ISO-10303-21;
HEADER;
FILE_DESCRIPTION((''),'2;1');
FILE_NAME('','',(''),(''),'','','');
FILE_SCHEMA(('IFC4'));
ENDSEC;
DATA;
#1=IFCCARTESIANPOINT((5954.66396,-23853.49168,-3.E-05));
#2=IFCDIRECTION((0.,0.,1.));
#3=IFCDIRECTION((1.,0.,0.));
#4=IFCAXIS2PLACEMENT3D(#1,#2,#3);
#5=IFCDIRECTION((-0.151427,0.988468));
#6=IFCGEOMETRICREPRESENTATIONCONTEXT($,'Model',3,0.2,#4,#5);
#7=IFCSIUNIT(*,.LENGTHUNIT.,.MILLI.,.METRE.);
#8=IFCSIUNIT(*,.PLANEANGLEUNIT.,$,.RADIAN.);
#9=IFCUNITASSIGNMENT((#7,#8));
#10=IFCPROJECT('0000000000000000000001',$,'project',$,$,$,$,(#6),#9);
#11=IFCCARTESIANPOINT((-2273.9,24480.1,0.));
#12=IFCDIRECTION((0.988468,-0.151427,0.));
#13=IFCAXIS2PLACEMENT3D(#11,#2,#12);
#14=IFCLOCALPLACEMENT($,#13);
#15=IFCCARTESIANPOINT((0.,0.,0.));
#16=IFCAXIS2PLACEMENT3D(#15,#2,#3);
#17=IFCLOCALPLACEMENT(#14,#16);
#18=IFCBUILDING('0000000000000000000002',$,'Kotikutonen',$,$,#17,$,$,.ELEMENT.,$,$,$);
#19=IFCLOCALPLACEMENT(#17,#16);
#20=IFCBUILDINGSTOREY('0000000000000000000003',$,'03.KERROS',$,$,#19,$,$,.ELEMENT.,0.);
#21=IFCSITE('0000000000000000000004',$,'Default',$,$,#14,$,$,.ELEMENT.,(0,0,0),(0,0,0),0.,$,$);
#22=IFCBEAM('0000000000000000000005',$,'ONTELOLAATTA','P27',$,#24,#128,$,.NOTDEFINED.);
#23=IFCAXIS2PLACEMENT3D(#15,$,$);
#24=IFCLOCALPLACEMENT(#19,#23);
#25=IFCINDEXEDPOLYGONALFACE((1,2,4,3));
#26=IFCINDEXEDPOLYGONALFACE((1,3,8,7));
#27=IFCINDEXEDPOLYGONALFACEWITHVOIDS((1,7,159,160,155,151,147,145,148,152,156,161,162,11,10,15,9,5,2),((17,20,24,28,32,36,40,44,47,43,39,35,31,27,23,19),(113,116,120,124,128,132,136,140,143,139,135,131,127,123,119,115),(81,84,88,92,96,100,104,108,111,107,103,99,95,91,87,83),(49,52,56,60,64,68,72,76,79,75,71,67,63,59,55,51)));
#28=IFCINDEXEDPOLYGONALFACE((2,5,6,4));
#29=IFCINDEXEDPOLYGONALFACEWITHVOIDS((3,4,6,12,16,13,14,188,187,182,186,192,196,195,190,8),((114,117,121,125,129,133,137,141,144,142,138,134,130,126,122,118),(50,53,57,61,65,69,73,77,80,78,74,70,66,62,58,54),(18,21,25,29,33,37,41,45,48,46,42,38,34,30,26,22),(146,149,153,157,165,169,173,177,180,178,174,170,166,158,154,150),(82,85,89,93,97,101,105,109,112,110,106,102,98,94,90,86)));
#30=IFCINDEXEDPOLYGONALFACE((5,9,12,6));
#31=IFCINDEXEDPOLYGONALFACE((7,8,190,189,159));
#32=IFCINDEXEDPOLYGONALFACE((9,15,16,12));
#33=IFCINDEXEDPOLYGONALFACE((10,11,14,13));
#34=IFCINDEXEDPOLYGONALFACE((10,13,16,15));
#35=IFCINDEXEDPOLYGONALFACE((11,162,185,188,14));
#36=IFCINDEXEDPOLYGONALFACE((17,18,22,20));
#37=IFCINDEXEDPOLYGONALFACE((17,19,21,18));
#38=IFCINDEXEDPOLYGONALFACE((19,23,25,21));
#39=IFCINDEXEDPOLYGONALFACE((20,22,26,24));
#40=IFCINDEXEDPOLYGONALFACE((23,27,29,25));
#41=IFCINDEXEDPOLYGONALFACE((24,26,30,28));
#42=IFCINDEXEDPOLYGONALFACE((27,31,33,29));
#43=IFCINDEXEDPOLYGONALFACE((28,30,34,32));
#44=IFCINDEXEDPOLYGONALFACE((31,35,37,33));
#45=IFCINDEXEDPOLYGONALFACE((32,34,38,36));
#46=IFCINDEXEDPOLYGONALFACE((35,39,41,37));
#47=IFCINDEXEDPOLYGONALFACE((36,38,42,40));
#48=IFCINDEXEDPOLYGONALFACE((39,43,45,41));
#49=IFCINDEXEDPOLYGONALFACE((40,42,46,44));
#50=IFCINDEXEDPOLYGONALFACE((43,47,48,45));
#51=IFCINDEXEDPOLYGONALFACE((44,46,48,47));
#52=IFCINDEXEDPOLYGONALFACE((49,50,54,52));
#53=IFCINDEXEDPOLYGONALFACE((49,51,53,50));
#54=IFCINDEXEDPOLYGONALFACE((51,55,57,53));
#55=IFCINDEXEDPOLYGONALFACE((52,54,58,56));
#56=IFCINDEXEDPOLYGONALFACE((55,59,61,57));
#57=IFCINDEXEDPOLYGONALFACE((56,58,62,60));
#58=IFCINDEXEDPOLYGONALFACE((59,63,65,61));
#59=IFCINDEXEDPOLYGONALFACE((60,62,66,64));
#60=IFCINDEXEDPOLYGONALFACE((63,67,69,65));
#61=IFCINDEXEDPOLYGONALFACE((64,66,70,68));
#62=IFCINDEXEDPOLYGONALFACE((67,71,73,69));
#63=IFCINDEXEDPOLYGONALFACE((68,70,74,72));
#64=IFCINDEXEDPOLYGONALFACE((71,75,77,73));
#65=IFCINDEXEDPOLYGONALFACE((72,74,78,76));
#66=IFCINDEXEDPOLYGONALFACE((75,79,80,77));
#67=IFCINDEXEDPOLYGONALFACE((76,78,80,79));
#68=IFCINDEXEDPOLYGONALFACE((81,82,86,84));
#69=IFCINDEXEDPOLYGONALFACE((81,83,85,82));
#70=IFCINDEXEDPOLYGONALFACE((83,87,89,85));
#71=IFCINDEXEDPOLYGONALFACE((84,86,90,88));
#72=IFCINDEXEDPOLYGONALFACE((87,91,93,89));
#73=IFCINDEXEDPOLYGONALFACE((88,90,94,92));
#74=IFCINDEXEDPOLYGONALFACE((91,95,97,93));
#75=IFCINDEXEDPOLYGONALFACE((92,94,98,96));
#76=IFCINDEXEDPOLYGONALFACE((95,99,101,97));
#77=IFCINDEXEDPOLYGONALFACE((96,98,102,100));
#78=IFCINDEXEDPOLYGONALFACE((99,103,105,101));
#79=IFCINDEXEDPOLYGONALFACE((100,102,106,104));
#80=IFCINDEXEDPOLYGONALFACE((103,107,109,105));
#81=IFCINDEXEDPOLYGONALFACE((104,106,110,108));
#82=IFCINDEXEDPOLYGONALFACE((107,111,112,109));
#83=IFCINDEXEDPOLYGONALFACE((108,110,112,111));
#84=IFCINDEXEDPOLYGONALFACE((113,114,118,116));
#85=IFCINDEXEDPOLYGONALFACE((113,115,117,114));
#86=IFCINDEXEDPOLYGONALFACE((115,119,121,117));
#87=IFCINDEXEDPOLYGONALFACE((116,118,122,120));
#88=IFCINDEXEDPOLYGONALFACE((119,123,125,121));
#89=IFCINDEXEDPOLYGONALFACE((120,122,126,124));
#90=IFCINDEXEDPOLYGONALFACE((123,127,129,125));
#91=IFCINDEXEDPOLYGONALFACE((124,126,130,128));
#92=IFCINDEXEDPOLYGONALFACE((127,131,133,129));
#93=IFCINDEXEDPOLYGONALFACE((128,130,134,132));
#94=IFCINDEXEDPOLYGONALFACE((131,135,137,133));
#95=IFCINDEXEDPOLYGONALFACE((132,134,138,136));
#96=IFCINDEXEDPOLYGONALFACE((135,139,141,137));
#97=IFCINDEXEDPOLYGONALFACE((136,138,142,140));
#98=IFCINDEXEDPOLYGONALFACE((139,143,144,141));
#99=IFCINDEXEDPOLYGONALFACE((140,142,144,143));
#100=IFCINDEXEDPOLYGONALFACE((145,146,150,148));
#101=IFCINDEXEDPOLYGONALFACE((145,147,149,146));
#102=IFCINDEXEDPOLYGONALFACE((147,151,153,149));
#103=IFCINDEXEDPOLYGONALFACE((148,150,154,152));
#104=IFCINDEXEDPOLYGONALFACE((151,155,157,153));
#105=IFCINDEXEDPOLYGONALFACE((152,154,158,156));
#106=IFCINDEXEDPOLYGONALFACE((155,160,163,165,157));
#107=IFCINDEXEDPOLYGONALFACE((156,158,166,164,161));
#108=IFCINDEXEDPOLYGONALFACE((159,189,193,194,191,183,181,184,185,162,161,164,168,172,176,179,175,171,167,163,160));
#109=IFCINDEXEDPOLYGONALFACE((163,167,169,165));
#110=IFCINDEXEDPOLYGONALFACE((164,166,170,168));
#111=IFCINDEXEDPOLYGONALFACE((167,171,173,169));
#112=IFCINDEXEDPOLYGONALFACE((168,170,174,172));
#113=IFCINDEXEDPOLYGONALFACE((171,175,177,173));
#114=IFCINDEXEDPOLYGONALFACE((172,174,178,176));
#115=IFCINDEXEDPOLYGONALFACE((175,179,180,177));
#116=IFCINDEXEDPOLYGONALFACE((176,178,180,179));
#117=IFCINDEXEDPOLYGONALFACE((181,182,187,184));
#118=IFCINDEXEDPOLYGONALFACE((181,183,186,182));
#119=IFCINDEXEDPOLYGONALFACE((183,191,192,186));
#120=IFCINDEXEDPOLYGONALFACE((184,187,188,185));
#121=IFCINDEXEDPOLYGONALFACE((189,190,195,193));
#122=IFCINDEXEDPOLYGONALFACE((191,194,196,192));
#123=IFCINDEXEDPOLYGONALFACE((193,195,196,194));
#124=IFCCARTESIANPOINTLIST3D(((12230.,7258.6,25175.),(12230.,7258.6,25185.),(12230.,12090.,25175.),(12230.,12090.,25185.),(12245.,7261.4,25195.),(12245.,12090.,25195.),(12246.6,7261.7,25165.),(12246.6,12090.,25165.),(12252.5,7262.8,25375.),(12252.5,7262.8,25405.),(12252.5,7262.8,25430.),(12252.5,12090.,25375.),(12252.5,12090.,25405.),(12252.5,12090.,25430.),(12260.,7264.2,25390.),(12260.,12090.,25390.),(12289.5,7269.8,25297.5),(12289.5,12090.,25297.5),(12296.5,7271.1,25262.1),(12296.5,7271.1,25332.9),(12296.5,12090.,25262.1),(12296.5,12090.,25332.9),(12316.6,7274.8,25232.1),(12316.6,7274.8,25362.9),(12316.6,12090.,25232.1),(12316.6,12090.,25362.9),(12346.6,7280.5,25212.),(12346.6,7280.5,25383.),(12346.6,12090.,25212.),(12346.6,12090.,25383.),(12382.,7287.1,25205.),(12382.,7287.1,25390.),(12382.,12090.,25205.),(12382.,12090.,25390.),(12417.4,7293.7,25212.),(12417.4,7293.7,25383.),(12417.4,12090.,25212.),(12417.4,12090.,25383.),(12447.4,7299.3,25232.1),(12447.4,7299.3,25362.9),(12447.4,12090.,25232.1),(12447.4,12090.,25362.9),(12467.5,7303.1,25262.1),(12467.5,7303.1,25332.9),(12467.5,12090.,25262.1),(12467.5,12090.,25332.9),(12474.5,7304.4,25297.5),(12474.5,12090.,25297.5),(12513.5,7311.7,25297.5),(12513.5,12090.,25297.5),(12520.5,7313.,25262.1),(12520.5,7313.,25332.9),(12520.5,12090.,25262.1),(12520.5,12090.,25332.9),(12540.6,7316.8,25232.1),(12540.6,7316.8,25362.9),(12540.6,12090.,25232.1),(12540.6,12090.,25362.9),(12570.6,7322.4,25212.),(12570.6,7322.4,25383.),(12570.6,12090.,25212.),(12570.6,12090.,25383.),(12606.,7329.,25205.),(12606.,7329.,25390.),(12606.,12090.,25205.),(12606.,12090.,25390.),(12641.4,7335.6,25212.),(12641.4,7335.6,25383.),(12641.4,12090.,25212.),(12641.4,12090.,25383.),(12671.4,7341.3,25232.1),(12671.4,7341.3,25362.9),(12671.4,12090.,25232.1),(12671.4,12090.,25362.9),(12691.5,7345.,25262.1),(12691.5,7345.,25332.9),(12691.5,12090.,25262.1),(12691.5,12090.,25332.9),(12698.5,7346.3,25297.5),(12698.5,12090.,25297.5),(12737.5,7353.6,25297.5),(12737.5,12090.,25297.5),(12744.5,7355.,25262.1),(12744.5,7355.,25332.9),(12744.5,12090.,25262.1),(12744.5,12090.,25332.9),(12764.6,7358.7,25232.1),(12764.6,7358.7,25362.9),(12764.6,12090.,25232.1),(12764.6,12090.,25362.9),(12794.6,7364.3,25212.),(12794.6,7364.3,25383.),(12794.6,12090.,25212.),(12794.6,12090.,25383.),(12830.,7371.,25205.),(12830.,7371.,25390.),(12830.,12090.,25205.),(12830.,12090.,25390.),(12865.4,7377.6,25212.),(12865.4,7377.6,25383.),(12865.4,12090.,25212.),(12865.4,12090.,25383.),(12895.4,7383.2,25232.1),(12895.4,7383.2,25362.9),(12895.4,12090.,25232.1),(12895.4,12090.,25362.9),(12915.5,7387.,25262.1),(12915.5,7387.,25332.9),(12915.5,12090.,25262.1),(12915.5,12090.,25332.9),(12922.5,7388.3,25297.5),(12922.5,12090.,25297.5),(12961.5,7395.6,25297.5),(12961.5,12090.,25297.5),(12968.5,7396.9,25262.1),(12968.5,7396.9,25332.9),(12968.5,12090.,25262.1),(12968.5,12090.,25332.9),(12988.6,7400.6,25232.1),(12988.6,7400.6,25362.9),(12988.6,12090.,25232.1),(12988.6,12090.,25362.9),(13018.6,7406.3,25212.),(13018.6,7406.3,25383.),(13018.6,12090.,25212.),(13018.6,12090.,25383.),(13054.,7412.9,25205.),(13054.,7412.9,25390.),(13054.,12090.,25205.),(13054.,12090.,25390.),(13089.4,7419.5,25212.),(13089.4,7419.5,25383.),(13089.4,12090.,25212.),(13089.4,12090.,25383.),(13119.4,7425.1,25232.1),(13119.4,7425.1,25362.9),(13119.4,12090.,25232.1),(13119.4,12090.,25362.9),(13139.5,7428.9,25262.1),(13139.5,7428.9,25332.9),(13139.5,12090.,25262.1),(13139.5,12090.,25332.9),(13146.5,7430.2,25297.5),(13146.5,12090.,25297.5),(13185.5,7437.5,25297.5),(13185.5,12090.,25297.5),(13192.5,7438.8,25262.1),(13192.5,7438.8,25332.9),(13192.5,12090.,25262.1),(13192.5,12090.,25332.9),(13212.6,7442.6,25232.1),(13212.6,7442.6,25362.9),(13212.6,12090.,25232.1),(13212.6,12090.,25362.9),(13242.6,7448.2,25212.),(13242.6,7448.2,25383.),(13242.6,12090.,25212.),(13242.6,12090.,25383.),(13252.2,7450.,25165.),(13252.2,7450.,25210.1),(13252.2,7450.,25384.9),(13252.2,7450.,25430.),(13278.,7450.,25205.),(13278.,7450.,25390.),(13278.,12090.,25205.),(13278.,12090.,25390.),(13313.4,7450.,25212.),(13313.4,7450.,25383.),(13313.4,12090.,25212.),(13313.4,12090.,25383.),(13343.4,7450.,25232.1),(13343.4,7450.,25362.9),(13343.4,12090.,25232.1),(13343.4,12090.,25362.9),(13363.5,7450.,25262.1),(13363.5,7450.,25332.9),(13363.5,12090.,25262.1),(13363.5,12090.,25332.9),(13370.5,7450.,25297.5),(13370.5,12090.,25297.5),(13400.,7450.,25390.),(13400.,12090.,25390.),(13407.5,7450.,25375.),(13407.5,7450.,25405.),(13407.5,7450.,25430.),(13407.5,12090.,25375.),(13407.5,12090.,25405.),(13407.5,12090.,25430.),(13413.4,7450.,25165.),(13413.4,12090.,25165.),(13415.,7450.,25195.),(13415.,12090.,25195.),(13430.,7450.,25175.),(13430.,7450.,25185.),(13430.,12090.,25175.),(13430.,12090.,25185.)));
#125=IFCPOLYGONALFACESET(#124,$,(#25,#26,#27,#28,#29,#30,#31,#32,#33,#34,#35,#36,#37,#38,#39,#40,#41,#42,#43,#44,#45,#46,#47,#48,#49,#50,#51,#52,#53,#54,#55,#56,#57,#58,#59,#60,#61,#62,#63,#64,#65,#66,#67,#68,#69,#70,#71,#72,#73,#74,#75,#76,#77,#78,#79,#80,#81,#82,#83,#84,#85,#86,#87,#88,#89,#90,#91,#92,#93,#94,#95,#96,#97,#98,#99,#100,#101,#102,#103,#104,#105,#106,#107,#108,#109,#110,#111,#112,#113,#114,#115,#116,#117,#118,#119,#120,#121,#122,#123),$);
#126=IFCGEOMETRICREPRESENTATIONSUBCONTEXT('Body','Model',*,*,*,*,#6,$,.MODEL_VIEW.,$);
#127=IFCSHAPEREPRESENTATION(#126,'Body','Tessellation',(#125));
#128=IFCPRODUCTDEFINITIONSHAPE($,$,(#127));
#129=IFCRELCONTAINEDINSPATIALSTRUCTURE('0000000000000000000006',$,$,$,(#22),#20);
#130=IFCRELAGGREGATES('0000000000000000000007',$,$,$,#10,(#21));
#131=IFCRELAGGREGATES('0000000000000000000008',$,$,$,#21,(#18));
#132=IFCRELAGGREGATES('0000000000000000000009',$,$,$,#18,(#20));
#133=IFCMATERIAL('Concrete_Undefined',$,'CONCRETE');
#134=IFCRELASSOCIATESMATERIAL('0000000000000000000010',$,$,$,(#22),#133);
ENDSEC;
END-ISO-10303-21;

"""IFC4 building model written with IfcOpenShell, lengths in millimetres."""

from ifc_helpers import new_model, si_unit, direction, frame, origin_with_axes, place, context, subcontext, project, spatial, line, indexed_curve, outline, extrude, material, element, save


model = new_model("IFC4")

# Units and contexts
model_context = context("Model", 3, precision=0.2, world=frame((5954.66396, -23853.49168, -3e-05), z_axis=(0.0, 0.0, 1.0), x_axis=(1.0, 0.0, 0.0)), true_north=direction((-0.151427, 0.988468)))
body_context = subcontext(model_context, "Body", "Model", "MODEL_VIEW")
ifc_project = project(units=[si_unit("LENGTHUNIT", "METRE", prefix="MILLI"), si_unit("PLANEANGLEUNIT", "RADIAN")], contexts=[model_context])

# Site, building, storey
site_placement = place(None, frame((-2273.9, 24480.1, 0.0), z_axis=(0.0, 0.0, 1.0), x_axis=(0.988468, -0.151427, 0.0)))
site = spatial("IfcSite", under=ifc_project, at=site_placement, Name="Default", CompositionType="ELEMENT", RefLatitude=(0, 0, 0), RefLongitude=(0, 0, 0), RefElevation=0.0)
building_placement = place(site_placement, origin_with_axes())
building = spatial("IfcBuilding", under=site, at=building_placement, Name="Kotikutonen", CompositionType="ELEMENT")
storey_placement = place(building_placement, origin_with_axes())
storey = spatial("IfcBuildingStorey", under=building, at=storey_placement, Name="03.KERROS", CompositionType="ELEMENT", Elevation=0.0)

# Shared definitions
ifc_material_1 = material(Name="Concrete_Undefined", Category="CONCRETE")

# Beam, voiding feature
beam_1_placement = place(storey_placement, frame((12830.0, 12090.0, 25297.5), z_axis=(-1.0, 0.0, 0.0), x_axis=(0.0, -1.0, 0.0)))
beam_1 = element("IfcBeam", 1, at=beam_1_placement, inside=storey, material=ifc_material_1, Name="ONTELOLAATTA", Description="P27", PredefinedType="NOTDEFINED", context=body_context, shape_type="SolidModel", body=[
    extrude(outline(indexed_curve([(-600.0, -122.5), (-583.4, -132.5), (583.4, -132.5), (600.0, -122.5), (600.0, -112.5), (585.0, -102.5), (577.5, 77.5), (570.0, 92.5), (577.5, 107.5), (577.5, 132.5), (-577.5, 132.5), (-577.5, 107.5), (-570.0, 92.5), (-577.5, 77.5), (-585.0, -102.5), (-600.0, -112.5)], segments=[line(1, 2, 3, 4, 5, 6, 7, 8, 9, 10, 11, 12, 13, 14, 15, 16, 1)]), holes=[indexed_curve([(-448.0, -92.5), (-483.4, -85.5), (-513.4, -65.4), (-533.5, -35.4), (-540.5, 0.0), (-533.5, 35.4), (-513.4, 65.4), (-483.4, 85.5), (-448.0, 92.5), (-412.6, 85.5), (-382.6, 65.4), (-362.5, 35.4), (-355.5, 0.0), (-362.5, -35.4), (-382.6, -65.4), (-412.6, -85.5)], segments=[line(1, 2, 3, 4, 5, 6, 7, 8, 9, 10, 11, 12, 13, 14, 15, 16, 1)]), indexed_curve([(-224.0, -92.5), (-259.4, -85.5), (-289.4, -65.4), (-309.5, -35.4), (-316.5, 0.0), (-309.5, 35.4), (-289.4, 65.4), (-259.4, 85.5), (-224.0, 92.5), (-188.6, 85.5), (-158.6, 65.4), (-138.5, 35.4), (-131.5, 0.0), (-138.5, -35.4), (-158.6, -65.4), (-188.6, -85.5)], segments=[line(1, 2, 3, 4, 5, 6, 7, 8, 9, 10, 11, 12, 13, 14, 15, 16, 1)]), indexed_curve([(0.0, -92.5), (-35.4, -85.5), (-65.4, -65.4), (-85.5, -35.4), (-92.5, 0.0), (-85.5, 35.4), (-65.4, 65.4), (-35.4, 85.5), (0.0, 92.5), (35.4, 85.5), (65.4, 65.4), (85.5, 35.4), (92.5, 0.0), (85.5, -35.4), (65.4, -65.4), (35.4, -85.5)], segments=[line(1, 2, 3, 4, 5, 6, 7, 8, 9, 10, 11, 12, 13, 14, 15, 16, 1)]), indexed_curve([(224.0, -92.5), (188.6, -85.5), (158.6, -65.4), (138.5, -35.4), (131.5, 0.0), (138.5, 35.4), (158.6, 65.4), (188.6, 85.5), (224.0, 92.5), (259.4, 85.5), (289.4, 65.4), (309.5, 35.4), (316.5, 0.0), (309.5, -35.4), (289.4, -65.4), (259.4, -85.5)], segments=[line(1, 2, 3, 4, 5, 6, 7, 8, 9, 10, 11, 12, 13, 14, 15, 16, 1)]), indexed_curve([(448.0, -92.5), (412.6, -85.5), (382.6, -65.4), (362.5, -35.4), (355.5, 0.0), (362.5, 35.4), (382.6, 65.4), (412.6, 85.5), (448.0, 92.5), (483.4, 85.5), (513.4, 65.4), (533.5, 35.4), (540.5, 0.0), (533.5, -35.4), (513.4, -65.4), (483.4, -85.5)], segments=[line(1, 2, 3, 4, 5, 6, 7, 8, 9, 10, 11, 12, 13, 14, 15, 16, 1)])]), frame((0.0, 0.0, 0.0), z_axis=(-1.0, 0.0, 0.0), x_axis=(0.0, 0.0, 1.0)), (0.0, 0.0, -1.0), 4831.4),
])
voiding_feature_1_placement = place(beam_1_placement, frame((4640.0, 0.0, -422.2), z_axis=(0.0, 1.0, 0.0), x_axis=(0.184024, 0.0, 0.982922)))
element("IfcVoidingFeature", 2, at=voiding_feature_1_placement, cuts=beam_1, Name="Opening", PredefinedType="HOLE", context=body_context, shape_type="SolidModel", body=[
    extrude(outline(indexed_curve([(0.0, 0.0), (1294.3, 0.0), (1331.7, 199.7), (-339.3, 512.6), (-420.5, 78.7)], segments=[line(1, 2, 3, 4, 5, 1)])), frame((0.0, 0.0, 207.5), z_axis=(0.0, 0.0, 1.0), x_axis=(1.0, 0.0, 0.0)), (0.0, 0.0, -1.0), 415.0),
])

save(model, "model.ifc")
